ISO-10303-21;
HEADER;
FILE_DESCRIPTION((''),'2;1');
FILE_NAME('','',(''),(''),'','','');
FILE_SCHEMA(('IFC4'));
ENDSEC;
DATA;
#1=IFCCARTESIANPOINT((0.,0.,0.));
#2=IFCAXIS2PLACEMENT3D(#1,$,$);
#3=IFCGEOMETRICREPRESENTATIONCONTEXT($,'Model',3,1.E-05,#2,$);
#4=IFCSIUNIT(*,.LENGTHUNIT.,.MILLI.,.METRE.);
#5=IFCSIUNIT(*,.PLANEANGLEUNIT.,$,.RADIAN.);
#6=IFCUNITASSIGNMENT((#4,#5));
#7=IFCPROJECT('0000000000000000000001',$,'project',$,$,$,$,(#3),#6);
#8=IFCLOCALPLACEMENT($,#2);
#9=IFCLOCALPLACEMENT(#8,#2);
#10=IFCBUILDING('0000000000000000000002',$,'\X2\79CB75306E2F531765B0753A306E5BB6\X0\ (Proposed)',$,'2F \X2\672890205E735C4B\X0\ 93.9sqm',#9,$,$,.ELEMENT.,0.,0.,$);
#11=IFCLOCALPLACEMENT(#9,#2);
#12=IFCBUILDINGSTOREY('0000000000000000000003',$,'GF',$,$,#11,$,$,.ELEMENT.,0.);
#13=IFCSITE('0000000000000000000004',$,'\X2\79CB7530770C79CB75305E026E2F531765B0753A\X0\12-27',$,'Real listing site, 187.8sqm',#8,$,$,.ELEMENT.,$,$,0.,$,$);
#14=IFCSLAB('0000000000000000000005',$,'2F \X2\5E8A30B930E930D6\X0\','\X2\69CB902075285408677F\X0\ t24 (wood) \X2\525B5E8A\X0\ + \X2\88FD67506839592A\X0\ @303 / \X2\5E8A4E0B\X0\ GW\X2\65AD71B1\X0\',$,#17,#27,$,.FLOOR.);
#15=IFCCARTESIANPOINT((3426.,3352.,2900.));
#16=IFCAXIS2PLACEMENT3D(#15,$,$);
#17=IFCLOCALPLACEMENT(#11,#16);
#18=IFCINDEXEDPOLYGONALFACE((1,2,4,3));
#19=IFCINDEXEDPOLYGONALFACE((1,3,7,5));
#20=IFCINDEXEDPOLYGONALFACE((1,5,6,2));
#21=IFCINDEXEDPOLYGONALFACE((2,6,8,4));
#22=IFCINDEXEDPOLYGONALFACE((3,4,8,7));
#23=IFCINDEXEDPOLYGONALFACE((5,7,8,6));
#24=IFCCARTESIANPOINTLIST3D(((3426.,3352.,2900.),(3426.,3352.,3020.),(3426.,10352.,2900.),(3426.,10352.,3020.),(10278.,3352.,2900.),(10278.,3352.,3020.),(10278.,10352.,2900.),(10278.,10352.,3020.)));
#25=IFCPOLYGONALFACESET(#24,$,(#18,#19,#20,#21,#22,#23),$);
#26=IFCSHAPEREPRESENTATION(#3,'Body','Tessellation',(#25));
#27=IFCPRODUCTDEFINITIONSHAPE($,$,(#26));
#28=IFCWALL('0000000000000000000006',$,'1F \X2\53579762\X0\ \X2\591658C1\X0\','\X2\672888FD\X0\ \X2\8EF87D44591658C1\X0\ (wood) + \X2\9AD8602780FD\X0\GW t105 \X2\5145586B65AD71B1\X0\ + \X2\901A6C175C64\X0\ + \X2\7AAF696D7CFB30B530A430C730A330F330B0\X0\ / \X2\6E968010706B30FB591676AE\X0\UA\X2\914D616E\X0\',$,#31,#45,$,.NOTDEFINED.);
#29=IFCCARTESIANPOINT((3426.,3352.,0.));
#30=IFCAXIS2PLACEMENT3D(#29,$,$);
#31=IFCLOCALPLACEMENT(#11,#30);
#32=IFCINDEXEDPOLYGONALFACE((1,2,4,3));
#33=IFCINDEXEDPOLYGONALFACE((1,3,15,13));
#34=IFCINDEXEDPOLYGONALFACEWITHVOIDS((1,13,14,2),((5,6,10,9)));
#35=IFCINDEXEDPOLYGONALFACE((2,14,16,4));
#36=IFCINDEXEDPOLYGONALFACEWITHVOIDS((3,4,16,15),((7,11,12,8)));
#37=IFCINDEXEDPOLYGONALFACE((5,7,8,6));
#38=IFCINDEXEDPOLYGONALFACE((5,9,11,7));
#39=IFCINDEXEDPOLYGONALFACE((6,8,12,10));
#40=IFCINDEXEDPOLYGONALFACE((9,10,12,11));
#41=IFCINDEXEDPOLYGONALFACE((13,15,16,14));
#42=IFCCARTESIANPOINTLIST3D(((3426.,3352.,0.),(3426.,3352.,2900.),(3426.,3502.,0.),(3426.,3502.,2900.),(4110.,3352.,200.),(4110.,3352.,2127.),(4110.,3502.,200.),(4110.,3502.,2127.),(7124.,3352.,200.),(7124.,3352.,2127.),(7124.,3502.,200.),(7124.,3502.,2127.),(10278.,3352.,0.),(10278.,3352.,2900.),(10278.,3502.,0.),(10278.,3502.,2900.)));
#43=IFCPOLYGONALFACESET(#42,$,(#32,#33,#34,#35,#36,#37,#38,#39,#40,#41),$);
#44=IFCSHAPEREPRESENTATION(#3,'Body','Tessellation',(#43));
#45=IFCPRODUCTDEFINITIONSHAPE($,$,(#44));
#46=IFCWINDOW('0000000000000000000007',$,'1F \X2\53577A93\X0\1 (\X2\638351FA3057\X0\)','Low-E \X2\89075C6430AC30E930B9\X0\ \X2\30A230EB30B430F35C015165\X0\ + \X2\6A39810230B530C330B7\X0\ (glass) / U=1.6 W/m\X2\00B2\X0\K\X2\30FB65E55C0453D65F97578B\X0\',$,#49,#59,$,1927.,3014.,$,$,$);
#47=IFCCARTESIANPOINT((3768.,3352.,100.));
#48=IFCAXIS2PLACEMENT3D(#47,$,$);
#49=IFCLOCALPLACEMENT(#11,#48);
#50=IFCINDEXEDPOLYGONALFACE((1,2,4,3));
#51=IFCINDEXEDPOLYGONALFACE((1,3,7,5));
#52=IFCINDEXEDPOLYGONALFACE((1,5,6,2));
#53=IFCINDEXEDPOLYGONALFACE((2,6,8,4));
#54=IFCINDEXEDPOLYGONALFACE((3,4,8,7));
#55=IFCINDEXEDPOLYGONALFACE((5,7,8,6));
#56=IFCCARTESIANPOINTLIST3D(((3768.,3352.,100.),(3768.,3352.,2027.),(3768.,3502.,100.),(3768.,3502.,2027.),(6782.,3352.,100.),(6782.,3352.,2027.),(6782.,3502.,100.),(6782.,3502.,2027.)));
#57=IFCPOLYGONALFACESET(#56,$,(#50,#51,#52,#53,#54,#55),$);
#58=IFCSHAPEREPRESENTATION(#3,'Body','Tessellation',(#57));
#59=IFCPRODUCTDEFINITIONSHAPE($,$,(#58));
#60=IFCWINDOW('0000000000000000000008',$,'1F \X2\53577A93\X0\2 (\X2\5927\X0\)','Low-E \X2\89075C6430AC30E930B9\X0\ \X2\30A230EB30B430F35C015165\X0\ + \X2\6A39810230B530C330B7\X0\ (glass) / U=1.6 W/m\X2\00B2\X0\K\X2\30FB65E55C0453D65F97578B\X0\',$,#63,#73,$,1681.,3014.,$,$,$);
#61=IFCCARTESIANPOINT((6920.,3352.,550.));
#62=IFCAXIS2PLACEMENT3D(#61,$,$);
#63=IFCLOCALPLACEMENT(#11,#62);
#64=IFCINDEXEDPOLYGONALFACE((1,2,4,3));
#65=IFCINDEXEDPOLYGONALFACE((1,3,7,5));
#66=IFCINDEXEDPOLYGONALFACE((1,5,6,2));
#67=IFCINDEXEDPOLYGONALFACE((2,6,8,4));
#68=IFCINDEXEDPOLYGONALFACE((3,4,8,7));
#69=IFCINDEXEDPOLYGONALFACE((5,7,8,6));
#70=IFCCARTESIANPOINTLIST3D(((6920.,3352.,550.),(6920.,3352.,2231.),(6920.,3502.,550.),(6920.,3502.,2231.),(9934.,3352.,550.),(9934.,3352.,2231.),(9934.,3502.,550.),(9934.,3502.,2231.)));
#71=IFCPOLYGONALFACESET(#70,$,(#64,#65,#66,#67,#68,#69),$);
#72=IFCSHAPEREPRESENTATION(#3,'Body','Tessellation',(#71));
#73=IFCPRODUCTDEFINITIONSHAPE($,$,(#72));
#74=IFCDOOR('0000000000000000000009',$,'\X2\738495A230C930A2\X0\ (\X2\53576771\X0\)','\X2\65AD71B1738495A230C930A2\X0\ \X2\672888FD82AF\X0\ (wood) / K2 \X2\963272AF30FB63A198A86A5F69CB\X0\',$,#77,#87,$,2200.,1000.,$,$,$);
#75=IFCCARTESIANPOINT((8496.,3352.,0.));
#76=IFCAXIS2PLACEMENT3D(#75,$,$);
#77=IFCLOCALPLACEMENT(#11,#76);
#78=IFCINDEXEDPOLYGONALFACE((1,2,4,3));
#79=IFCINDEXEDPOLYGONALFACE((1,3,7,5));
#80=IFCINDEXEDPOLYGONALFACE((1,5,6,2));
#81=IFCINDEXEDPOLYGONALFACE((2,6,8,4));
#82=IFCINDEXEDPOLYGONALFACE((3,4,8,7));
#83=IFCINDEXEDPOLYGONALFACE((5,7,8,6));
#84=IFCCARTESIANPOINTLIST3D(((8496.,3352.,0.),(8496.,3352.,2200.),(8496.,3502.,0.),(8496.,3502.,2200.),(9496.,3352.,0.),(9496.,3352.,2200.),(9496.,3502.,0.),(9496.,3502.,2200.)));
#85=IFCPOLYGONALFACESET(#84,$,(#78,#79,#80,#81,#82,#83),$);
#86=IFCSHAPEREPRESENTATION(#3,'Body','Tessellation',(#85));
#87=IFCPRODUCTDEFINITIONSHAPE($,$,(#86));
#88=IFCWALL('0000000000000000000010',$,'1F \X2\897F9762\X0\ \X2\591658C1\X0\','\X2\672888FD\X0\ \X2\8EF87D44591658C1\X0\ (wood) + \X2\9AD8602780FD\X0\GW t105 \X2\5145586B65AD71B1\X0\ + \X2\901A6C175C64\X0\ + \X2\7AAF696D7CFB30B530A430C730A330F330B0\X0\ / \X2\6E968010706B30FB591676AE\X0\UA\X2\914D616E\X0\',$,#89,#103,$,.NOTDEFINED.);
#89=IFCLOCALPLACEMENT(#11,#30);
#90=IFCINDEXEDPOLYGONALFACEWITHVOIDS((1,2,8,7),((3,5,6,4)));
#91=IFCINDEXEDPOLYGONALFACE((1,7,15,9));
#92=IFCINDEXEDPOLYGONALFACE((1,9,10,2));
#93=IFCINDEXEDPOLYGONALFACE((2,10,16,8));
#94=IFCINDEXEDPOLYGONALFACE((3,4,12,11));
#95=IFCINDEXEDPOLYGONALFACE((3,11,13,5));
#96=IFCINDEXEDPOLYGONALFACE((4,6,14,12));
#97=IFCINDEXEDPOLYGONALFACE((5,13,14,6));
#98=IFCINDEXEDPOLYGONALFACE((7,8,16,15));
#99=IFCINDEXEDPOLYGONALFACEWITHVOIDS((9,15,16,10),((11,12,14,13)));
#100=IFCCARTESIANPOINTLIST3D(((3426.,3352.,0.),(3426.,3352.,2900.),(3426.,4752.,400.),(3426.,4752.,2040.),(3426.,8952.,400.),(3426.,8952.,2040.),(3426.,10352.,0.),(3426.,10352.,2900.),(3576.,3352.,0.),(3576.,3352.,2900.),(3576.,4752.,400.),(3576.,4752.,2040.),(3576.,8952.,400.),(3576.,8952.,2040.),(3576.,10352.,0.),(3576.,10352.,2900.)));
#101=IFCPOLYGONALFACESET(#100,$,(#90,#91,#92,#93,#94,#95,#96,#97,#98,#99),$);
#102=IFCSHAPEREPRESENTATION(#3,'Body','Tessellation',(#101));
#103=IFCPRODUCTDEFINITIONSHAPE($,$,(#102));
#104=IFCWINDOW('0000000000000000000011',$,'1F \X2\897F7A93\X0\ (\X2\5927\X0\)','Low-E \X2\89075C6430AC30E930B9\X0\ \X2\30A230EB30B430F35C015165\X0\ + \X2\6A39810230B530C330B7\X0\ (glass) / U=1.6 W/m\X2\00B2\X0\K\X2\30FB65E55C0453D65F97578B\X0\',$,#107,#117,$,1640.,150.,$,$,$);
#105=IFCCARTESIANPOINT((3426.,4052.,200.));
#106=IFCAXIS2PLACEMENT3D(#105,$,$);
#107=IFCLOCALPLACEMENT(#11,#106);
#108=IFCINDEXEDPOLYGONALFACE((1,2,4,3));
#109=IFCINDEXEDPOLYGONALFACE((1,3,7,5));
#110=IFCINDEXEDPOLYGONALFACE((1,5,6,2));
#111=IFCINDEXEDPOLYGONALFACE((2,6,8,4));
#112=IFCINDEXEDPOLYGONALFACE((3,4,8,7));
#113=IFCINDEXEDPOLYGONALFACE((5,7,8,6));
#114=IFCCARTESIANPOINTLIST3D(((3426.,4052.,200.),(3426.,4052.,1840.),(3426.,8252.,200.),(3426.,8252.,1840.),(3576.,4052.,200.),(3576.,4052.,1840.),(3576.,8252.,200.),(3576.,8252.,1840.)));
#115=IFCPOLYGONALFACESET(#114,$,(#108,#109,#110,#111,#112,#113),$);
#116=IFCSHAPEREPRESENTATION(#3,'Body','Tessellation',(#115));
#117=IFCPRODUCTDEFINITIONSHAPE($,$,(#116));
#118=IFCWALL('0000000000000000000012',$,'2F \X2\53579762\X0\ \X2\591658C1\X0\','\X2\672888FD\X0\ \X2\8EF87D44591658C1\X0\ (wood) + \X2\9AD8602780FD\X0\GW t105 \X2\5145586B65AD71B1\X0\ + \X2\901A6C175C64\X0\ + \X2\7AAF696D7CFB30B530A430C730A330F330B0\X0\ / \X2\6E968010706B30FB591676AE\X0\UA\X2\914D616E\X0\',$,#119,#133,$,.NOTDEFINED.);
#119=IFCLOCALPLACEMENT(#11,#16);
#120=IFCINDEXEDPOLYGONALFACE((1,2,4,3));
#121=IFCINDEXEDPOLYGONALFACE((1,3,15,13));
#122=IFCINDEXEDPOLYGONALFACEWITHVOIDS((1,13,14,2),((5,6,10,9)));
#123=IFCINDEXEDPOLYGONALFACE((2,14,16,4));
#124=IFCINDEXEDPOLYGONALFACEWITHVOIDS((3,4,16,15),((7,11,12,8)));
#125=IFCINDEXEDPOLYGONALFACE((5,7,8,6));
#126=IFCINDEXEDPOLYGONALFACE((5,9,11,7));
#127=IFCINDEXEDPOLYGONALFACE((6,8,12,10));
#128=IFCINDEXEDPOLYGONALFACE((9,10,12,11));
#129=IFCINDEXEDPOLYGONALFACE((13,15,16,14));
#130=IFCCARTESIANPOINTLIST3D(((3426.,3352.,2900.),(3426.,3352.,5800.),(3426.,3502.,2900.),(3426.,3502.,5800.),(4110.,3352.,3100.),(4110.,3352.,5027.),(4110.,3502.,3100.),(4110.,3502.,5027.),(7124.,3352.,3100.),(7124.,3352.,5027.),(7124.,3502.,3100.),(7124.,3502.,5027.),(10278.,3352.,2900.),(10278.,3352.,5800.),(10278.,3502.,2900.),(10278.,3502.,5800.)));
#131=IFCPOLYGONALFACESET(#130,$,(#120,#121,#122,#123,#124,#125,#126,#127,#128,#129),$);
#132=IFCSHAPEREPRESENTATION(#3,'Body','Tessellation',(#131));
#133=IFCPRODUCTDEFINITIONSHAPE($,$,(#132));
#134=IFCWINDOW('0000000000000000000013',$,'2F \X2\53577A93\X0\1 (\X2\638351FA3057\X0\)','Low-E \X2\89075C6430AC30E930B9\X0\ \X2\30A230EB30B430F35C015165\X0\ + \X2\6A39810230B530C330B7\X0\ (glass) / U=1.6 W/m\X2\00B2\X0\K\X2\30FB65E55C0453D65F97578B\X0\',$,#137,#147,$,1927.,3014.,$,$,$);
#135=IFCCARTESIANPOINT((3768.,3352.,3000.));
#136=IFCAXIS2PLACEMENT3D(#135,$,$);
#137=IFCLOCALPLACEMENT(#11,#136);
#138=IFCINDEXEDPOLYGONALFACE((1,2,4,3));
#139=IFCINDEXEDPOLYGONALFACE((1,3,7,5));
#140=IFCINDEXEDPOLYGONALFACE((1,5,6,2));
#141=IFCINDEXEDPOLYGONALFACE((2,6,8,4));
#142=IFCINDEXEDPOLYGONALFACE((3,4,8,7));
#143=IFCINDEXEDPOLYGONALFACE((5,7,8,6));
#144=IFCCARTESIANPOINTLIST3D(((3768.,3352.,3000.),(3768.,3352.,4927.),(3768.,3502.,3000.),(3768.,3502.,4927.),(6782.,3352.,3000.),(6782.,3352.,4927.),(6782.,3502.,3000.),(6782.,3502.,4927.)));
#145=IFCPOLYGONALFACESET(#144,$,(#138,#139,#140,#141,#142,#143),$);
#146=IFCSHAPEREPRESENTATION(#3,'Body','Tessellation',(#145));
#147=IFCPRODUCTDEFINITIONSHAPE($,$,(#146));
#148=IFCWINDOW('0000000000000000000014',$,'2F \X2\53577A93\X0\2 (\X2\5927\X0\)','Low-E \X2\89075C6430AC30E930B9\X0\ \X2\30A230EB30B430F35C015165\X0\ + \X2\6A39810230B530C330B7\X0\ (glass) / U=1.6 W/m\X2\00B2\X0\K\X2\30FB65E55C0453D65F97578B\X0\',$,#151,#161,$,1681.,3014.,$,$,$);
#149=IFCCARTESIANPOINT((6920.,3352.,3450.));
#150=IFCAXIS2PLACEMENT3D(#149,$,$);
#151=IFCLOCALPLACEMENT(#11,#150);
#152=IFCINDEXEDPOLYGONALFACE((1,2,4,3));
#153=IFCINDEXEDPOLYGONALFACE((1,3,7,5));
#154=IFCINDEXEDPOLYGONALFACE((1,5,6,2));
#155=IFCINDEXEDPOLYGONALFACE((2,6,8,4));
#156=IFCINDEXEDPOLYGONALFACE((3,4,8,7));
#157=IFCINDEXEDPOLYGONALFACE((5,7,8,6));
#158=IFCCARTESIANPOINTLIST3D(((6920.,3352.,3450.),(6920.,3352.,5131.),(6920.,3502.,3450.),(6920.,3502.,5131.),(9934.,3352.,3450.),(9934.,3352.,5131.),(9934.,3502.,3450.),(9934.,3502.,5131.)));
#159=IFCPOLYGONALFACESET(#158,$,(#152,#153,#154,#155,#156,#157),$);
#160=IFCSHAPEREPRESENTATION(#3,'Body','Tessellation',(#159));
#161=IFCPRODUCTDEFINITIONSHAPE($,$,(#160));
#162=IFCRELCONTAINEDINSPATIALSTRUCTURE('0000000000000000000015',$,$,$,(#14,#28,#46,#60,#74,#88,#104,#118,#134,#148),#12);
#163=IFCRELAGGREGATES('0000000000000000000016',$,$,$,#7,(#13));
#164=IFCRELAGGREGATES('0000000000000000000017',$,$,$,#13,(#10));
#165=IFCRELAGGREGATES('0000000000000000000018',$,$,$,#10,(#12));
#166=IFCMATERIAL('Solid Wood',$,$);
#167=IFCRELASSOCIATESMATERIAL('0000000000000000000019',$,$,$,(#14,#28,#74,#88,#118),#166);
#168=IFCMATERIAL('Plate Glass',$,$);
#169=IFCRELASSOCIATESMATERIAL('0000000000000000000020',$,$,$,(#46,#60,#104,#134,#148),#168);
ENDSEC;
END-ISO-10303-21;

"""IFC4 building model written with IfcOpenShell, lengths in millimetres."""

from ifc_helpers import new_model, si_unit, frame, frame_2d, origin, place, context, project, spatial, rectangle, extrude, material, element, fill, save


model = new_model("IFC4")

# Units and contexts
model_context = context("Model", 3, precision=1e-05, world=origin())
ifc_project = project(units=[si_unit("LENGTHUNIT", "METRE", prefix="MILLI"), si_unit("PLANEANGLEUNIT", "RADIAN")], contexts=[model_context])

# Site, building, storey
site_placement = place(None, origin())
site = spatial("IfcSite", under=ifc_project, at=site_placement, Name="秋田県秋田市港北新町12-27", ObjectType="Real listing site, 187.8sqm", CompositionType="ELEMENT", RefElevation=0.0)
building_placement = place(site_placement, origin())
building = spatial("IfcBuilding", under=site, at=building_placement, Name="秋田港北新町の家 (Proposed)", ObjectType="2F 木造平屋 93.9sqm", CompositionType="ELEMENT", ElevationOfRefHeight=0.0, ElevationOfTerrain=0.0)
storey_placement = place(building_placement, origin())
storey = spatial("IfcBuildingStorey", under=building, at=storey_placement, Name="GF", CompositionType="ELEMENT", Elevation=0.0)

# Slab
ifc_material_1 = material(Name="Solid Wood")
slab_1_placement = place(storey_placement, frame((3426.0, 3352.0, 2900.0)))
element("IfcSlab", 1, at=slab_1_placement, inside=storey, material=ifc_material_1, Name="2F 床スラブ", Description="構造用合板 t24 (wood) 剛床 + 製材根太 @303 / 床下 GW断熱", PredefinedType="FLOOR", context=model_context, shape_type="SweptSolid", body=[
    extrude(rectangle(XDim=6852.0, YDim=7000.0, at=frame_2d((3426.0, 3500.0))), frame((3426.0, 3352.0, 2900.0)), (0.0, 0.0, 1.0), 120.0),
])

# Wall, openings, windows, door
wall_1_placement = place(storey_placement, frame((3426.0, 3352.0, 0.0)))
wall_1 = element("IfcWall", 2, at=wall_1_placement, inside=storey, material=ifc_material_1, Name="1F 南面 外壁", Description="木製 軸組外壁 (wood) + 高性能GW t105 充填断熱 + 通気層 + 窯業系サイディング / 準耐火・外皮UA配慮", PredefinedType="NOTDEFINED", context=model_context, shape_type="SweptSolid", body=[
    extrude(rectangle(XDim=6852.0, YDim=150.0, at=frame_2d((3426.0, 75.0))), frame((3426.0, 3352.0, 0.0)), (0.0, 0.0, 1.0), 2900.0),
])
opening_1_placement = place(storey_placement, frame((3768.0, 3352.0, 100.0)))
opening_1 = element("IfcOpeningElement", 3, at=opening_1_placement, cuts=wall_1, PredefinedType="NOTDEFINED", context=model_context, shape_type="SweptSolid", body=[
    extrude(rectangle(XDim=3014.0, YDim=150.0, at=frame_2d((1507.0, 75.0))), frame((3768.0, 3352.0, 100.0)), (0.0, 0.0, 1.0), 1927.0),
])
opening_2_placement = place(storey_placement, frame((6920.0, 3352.0, 550.0)))
opening_2 = element("IfcOpeningElement", 4, at=opening_2_placement, cuts=wall_1, PredefinedType="NOTDEFINED", context=model_context, shape_type="SweptSolid", body=[
    extrude(rectangle(XDim=3014.0, YDim=150.0, at=frame_2d((1507.0, 75.0))), frame((6920.0, 3352.0, 550.0)), (0.0, 0.0, 1.0), 1681.0),
])
opening_3_placement = place(storey_placement, frame((8496.0, 3352.0, 0.0)))
opening_3 = element("IfcOpeningElement", 5, at=opening_3_placement, cuts=wall_1, PredefinedType="NOTDEFINED", context=model_context, shape_type="SweptSolid", body=[
    extrude(rectangle(XDim=1000.0, YDim=150.0, at=frame_2d((500.0, 75.0))), frame((8496.0, 3352.0, 0.0)), (0.0, 0.0, 1.0), 2200.0),
])
ifc_material_2 = material(Name="Plate Glass")
window_1_placement = place(storey_placement, frame((3768.0, 3352.0, 100.0)))
window_1 = element("IfcWindow", 6, at=window_1_placement, inside=storey, material=ifc_material_2, Name="1F 南窓1 (掃出し)", Description="Low-E 複層ガラス アルゴン封入 + 樹脂サッシ (glass) / U=1.6 W/m²K・日射取得型", OverallHeight=1927.0, OverallWidth=3014.0, context=model_context, shape_type="SweptSolid", body=[
    extrude(rectangle(XDim=3014.0, YDim=150.0, at=frame_2d((1507.0, 75.0))), frame((3768.0, 3352.0, 100.0)), (0.0, 0.0, 1.0), 1927.0),
])
fill(opening_1, window_1)
window_2_placement = place(storey_placement, frame((6920.0, 3352.0, 550.0)))
window_2 = element("IfcWindow", 7, at=window_2_placement, inside=storey, material=ifc_material_2, Name="1F 南窓2 (大)", Description="Low-E 複層ガラス アルゴン封入 + 樹脂サッシ (glass) / U=1.6 W/m²K・日射取得型", OverallHeight=1681.0, OverallWidth=3014.0, context=model_context, shape_type="SweptSolid", body=[
    extrude(rectangle(XDim=3014.0, YDim=150.0, at=frame_2d((1507.0, 75.0))), frame((6920.0, 3352.0, 550.0)), (0.0, 0.0, 1.0), 1681.0),
])
fill(opening_2, window_2)
door_placement = place(storey_placement, frame((8496.0, 3352.0, 0.0)))
door = element("IfcDoor", 8, at=door_placement, inside=storey, material=ifc_material_1, Name="玄関ドア (南東)", Description="断熱玄関ドア 木製芯 (wood) / K2 防犯・採風機構", OverallHeight=2200.0, OverallWidth=1000.0, context=model_context, shape_type="SweptSolid", body=[
    extrude(rectangle(XDim=1000.0, YDim=150.0, at=frame_2d((500.0, 75.0))), frame((8496.0, 3352.0, 0.0)), (0.0, 0.0, 1.0), 2200.0),
])
fill(opening_3, door)

# Wall, opening, window
wall_2_placement = place(storey_placement, frame((3426.0, 3352.0, 0.0)))
wall_2 = element("IfcWall", 9, at=wall_2_placement, inside=storey, material=ifc_material_1, Name="1F 西面 外壁", Description="木製 軸組外壁 (wood) + 高性能GW t105 充填断熱 + 通気層 + 窯業系サイディング / 準耐火・外皮UA配慮", PredefinedType="NOTDEFINED", context=model_context, shape_type="SweptSolid", body=[
    extrude(rectangle(XDim=150.0, YDim=7000.0, at=frame_2d((75.0, 3500.0))), frame((3426.0, 3352.0, 0.0)), (0.0, 0.0, 1.0), 2900.0),
])
opening_4_placement = place(storey_placement, frame((3426.0, 4052.0, 200.0)))
opening_4 = element("IfcOpeningElement", 10, at=opening_4_placement, cuts=wall_2, PredefinedType="NOTDEFINED", context=model_context, shape_type="SweptSolid", body=[
    extrude(rectangle(XDim=150.0, YDim=4200.0, at=frame_2d((75.0, 2100.0))), frame((3426.0, 4052.0, 200.0)), (0.0, 0.0, 1.0), 1640.0),
])
window_3_placement = place(storey_placement, frame((3426.0, 4052.0, 200.0)))
window_3 = element("IfcWindow", 11, at=window_3_placement, inside=storey, material=ifc_material_2, Name="1F 西窓 (大)", Description="Low-E 複層ガラス アルゴン封入 + 樹脂サッシ (glass) / U=1.6 W/m²K・日射取得型", OverallHeight=1640.0, OverallWidth=150.0, context=model_context, shape_type="SweptSolid", body=[
    extrude(rectangle(XDim=150.0, YDim=4200.0, at=frame_2d((75.0, 2100.0))), frame((3426.0, 4052.0, 200.0)), (0.0, 0.0, 1.0), 1640.0),
])
fill(opening_4, window_3)

# Wall, openings, windows
wall_3_placement = place(storey_placement, frame((3426.0, 3352.0, 2900.0)))
wall_3 = element("IfcWall", 12, at=wall_3_placement, inside=storey, material=ifc_material_1, Name="2F 南面 外壁", Description="木製 軸組外壁 (wood) + 高性能GW t105 充填断熱 + 通気層 + 窯業系サイディング / 準耐火・外皮UA配慮", PredefinedType="NOTDEFINED", context=model_context, shape_type="SweptSolid", body=[
    extrude(rectangle(XDim=6852.0, YDim=150.0, at=frame_2d((3426.0, 75.0))), frame((3426.0, 3352.0, 2900.0)), (0.0, 0.0, 1.0), 2900.0),
])
opening_5_placement = place(storey_placement, frame((3768.0, 3352.0, 3000.0)))
opening_5 = element("IfcOpeningElement", 13, at=opening_5_placement, cuts=wall_3, PredefinedType="NOTDEFINED", context=model_context, shape_type="SweptSolid", body=[
    extrude(rectangle(XDim=3014.0, YDim=150.0, at=frame_2d((1507.0, 75.0))), frame((3768.0, 3352.0, 3000.0)), (0.0, 0.0, 1.0), 1927.0),
])
opening_6_placement = place(storey_placement, frame((6920.0, 3352.0, 3450.0)))
opening_6 = element("IfcOpeningElement", 14, at=opening_6_placement, cuts=wall_3, PredefinedType="NOTDEFINED", context=model_context, shape_type="SweptSolid", body=[
    extrude(rectangle(XDim=3014.0, YDim=150.0, at=frame_2d((1507.0, 75.0))), frame((6920.0, 3352.0, 3450.0)), (0.0, 0.0, 1.0), 1681.0),
])
window_4_placement = place(storey_placement, frame((3768.0, 3352.0, 3000.0)))
window_4 = element("IfcWindow", 15, at=window_4_placement, inside=storey, material=ifc_material_2, Name="2F 南窓1 (掃出し)", Description="Low-E 複層ガラス アルゴン封入 + 樹脂サッシ (glass) / U=1.6 W/m²K・日射取得型", OverallHeight=1927.0, OverallWidth=3014.0, context=model_context, shape_type="SweptSolid", body=[
    extrude(rectangle(XDim=3014.0, YDim=150.0, at=frame_2d((1507.0, 75.0))), frame((3768.0, 3352.0, 3000.0)), (0.0, 0.0, 1.0), 1927.0),
])
fill(opening_5, window_4)
window_5_placement = place(storey_placement, frame((6920.0, 3352.0, 3450.0)))
window_5 = element("IfcWindow", 16, at=window_5_placement, inside=storey, material=ifc_material_2, Name="2F 南窓2 (大)", Description="Low-E 複層ガラス アルゴン封入 + 樹脂サッシ (glass) / U=1.6 W/m²K・日射取得型", OverallHeight=1681.0, OverallWidth=3014.0, context=model_context, shape_type="SweptSolid", body=[
    extrude(rectangle(XDim=3014.0, YDim=150.0, at=frame_2d((1507.0, 75.0))), frame((6920.0, 3352.0, 3450.0)), (0.0, 0.0, 1.0), 1681.0),
])
fill(opening_6, window_5)

save(model, "model.ifc")
